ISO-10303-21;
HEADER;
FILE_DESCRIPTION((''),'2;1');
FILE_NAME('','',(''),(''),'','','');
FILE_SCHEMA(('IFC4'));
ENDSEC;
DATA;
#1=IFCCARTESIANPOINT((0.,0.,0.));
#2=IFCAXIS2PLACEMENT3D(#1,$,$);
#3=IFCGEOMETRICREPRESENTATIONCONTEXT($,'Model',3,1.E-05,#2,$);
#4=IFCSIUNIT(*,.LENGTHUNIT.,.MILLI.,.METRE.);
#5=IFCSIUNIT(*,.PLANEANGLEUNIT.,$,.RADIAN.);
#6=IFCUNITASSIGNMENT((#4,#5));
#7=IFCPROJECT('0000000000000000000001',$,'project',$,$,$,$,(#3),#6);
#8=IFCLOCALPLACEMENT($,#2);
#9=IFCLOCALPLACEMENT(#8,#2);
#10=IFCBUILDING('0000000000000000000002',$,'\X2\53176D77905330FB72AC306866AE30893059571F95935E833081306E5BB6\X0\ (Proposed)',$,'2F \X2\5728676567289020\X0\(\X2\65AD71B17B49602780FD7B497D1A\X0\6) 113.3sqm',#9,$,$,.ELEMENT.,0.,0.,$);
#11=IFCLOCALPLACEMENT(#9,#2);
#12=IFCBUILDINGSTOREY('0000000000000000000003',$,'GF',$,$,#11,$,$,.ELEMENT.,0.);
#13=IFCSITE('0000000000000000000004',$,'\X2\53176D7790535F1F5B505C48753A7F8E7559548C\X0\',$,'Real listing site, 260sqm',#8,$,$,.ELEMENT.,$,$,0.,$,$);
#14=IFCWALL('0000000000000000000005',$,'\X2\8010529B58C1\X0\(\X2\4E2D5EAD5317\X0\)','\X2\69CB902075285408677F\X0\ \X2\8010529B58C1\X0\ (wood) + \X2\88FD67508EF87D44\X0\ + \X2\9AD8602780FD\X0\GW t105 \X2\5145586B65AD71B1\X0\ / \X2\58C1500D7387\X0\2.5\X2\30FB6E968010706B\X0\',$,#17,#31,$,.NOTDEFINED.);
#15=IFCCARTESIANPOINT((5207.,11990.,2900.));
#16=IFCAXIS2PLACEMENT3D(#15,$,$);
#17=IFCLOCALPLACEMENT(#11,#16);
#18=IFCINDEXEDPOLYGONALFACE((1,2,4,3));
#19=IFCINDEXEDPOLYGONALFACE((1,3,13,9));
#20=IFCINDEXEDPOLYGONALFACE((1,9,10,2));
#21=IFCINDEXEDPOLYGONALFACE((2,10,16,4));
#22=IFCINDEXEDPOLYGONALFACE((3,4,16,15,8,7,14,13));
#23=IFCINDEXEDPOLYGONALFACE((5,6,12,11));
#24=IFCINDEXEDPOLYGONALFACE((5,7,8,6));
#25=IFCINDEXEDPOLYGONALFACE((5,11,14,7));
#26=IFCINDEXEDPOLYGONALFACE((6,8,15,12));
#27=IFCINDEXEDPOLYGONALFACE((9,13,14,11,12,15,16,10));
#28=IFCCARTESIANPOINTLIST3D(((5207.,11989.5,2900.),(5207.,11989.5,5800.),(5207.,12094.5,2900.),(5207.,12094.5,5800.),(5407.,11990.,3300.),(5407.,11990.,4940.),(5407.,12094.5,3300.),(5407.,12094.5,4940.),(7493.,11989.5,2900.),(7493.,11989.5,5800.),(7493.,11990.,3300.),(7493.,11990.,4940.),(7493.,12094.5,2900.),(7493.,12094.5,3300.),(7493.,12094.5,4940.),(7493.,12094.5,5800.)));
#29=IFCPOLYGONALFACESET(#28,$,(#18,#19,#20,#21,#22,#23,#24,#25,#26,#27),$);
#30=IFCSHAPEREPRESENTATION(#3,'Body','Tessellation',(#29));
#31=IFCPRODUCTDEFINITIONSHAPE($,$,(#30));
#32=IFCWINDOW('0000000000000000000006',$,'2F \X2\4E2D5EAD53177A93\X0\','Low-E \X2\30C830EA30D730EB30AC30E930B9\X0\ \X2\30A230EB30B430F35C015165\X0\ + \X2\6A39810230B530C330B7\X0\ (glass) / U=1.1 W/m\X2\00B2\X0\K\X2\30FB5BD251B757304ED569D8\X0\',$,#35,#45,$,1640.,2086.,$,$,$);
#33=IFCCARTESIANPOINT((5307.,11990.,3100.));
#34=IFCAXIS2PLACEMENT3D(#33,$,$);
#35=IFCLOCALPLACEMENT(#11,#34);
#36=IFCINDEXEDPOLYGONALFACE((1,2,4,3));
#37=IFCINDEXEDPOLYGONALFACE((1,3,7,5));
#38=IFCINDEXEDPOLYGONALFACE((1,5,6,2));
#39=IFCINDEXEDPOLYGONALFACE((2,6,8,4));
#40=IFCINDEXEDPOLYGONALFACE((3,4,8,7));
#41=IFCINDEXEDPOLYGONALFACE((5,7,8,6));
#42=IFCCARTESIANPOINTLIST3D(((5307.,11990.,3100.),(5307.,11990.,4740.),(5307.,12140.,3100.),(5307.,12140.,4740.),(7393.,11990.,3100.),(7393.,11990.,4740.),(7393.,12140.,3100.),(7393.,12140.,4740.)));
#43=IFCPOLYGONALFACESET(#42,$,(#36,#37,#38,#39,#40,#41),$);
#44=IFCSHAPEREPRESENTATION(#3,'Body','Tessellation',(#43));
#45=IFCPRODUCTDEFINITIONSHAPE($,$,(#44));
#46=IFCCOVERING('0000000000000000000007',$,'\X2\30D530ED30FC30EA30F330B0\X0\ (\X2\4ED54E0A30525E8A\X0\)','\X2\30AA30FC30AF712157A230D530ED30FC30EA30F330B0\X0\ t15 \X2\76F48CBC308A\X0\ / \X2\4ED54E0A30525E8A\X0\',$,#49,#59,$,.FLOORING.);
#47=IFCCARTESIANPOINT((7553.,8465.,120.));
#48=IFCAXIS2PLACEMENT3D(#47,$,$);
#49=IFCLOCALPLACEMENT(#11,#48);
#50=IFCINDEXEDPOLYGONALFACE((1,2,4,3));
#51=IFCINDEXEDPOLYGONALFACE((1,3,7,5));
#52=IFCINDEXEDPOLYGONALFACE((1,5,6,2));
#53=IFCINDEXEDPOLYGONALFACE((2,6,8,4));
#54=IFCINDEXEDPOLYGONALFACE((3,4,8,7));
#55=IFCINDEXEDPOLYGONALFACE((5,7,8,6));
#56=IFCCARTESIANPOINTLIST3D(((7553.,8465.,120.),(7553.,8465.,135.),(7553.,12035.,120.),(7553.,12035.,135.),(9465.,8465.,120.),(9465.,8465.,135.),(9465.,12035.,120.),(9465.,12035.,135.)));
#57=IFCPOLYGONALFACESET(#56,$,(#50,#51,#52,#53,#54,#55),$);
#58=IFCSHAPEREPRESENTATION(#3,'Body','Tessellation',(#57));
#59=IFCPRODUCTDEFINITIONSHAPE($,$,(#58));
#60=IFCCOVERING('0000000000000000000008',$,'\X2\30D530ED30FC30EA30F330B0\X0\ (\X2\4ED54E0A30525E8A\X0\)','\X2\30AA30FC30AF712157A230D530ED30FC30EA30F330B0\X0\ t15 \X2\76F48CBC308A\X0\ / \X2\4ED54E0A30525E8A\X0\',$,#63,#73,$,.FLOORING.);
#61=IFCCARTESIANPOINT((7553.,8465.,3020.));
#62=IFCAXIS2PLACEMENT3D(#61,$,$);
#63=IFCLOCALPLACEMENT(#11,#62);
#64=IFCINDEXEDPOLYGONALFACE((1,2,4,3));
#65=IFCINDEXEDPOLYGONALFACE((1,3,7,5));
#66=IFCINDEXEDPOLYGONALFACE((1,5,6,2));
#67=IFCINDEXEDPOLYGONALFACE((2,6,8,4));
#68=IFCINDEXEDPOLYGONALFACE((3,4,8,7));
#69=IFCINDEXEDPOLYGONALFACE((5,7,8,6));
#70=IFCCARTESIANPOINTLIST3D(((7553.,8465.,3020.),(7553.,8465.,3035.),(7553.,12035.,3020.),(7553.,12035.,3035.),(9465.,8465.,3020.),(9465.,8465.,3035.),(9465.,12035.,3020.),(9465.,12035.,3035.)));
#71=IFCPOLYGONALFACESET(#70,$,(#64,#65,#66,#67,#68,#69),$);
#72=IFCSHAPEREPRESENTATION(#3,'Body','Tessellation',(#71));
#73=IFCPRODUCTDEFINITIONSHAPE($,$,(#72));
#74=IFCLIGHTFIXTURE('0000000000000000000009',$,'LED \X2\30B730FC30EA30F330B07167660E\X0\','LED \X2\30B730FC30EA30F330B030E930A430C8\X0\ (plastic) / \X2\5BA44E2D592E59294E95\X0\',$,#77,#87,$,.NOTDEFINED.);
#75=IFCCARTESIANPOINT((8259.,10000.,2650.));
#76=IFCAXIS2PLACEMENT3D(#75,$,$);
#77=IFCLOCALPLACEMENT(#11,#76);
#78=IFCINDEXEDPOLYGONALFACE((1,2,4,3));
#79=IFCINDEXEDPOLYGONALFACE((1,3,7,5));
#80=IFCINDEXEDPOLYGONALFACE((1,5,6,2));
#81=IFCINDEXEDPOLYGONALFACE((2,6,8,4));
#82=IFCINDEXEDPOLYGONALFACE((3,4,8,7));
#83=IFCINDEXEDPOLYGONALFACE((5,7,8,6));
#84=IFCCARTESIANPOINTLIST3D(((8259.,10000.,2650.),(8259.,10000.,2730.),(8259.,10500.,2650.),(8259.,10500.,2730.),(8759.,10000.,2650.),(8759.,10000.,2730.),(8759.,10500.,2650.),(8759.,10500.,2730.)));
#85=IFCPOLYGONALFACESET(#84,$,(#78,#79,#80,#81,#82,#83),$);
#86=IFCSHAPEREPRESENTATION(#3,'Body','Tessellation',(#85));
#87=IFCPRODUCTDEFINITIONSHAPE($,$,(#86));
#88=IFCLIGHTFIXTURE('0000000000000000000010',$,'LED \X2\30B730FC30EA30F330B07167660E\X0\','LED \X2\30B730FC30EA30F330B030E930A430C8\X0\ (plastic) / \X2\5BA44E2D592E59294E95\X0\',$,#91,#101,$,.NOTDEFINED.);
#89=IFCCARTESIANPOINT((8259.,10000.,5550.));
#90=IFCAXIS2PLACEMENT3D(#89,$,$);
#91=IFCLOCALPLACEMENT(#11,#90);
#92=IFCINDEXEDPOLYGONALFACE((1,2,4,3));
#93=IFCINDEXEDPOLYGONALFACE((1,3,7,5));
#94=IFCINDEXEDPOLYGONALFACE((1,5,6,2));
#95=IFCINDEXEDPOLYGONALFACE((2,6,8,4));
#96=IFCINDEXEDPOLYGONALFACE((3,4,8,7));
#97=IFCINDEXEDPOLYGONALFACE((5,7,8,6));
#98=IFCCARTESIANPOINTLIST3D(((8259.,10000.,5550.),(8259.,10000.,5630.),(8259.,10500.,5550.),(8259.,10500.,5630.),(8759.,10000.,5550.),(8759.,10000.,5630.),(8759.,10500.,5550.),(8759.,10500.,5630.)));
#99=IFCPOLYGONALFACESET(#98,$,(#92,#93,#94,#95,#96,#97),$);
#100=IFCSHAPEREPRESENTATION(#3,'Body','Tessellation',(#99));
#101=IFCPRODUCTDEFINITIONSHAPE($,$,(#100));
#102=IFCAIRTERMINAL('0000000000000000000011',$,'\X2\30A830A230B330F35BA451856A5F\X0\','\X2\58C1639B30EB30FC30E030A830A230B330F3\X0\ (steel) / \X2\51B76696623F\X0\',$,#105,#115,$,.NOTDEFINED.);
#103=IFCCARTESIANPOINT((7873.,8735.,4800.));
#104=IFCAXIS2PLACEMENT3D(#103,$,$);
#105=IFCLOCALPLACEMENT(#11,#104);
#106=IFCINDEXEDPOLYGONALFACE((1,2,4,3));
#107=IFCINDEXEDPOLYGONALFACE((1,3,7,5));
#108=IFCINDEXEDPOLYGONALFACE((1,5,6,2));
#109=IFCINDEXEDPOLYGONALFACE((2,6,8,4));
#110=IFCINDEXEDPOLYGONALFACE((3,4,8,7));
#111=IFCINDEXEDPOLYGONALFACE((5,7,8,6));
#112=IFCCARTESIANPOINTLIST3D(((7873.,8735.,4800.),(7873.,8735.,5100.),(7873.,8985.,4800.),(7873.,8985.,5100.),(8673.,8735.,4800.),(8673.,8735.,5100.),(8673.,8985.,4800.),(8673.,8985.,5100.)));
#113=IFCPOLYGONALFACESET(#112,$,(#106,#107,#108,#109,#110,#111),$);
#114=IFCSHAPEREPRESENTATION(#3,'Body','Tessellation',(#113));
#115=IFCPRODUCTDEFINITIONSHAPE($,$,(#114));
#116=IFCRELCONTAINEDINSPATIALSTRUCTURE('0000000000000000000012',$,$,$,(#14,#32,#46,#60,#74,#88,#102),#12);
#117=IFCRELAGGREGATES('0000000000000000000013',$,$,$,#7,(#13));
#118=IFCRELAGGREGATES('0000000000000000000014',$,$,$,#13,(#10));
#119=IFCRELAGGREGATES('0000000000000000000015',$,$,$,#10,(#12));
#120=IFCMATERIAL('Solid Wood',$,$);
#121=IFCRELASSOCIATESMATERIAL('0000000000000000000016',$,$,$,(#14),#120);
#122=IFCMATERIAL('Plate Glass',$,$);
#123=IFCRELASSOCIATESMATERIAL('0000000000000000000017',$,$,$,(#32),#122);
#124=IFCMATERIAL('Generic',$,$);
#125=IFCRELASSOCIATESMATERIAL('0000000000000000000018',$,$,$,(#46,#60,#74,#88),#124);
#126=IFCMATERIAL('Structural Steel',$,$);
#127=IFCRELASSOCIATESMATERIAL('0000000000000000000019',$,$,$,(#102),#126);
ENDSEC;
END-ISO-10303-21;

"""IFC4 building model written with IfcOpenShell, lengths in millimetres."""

from ifc_helpers import new_model, si_unit, frame, frame_2d, origin, place, context, project, spatial, rectangle, extrude, material, element, fill, save


model = new_model("IFC4")

# Units and contexts
model_context = context("Model", 3, precision=1e-05, world=origin())
ifc_project = project(units=[si_unit("LENGTHUNIT", "METRE", prefix="MILLI"), si_unit("PLANEANGLEUNIT", "RADIAN")], contexts=[model_context])

# Site, building, storey
site_placement = place(None, origin())
site = spatial("IfcSite", under=ifc_project, at=site_placement, Name="北海道弟子屈町美留和", ObjectType="Real listing site, 260sqm", CompositionType="ELEMENT", RefElevation=0.0)
building_placement = place(site_placement, origin())
building = spatial("IfcBuilding", under=site, at=building_placement, Name="北海道・犬と暮らす土間広めの家 (Proposed)", ObjectType="2F 在来木造(断熱等性能等級6) 113.3sqm", CompositionType="ELEMENT", ElevationOfRefHeight=0.0, ElevationOfTerrain=0.0)
storey_placement = place(building_placement, origin())
storey = spatial("IfcBuildingStorey", under=building, at=storey_placement, Name="GF", CompositionType="ELEMENT", Elevation=0.0)

# Shared definitions
ifc_material_1 = material(Name="Solid Wood")

# Wall, opening, window
ifc_material_2 = material(Name="Plate Glass")
wall_1_placement = place(storey_placement, frame((5207.0, 11990.0, 2900.0)))
wall_1 = element("IfcWall", 1, at=wall_1_placement, inside=storey, material=ifc_material_1, Name="耐力壁(中庭北)", Description="構造用合板 耐力壁 (wood) + 製材軸組 + 高性能GW t105 充填断熱 / 壁倍率2.5・準耐火", PredefinedType="NOTDEFINED", context=model_context, shape_type="SweptSolid", body=[
    extrude(rectangle(XDim=2286.0, YDim=105.0, at=frame_2d((1143.0, 52.0))), frame((5207.0, 11990.0, 2900.0)), (0.0, 0.0, 1.0), 2900.0),
])
opening_1_placement = place(storey_placement, frame((5307.0, 11990.0, 3100.0)))
opening_1 = element("IfcOpeningElement", 2, at=opening_1_placement, cuts=wall_1, PredefinedType="NOTDEFINED", context=model_context, shape_type="SweptSolid", body=[
    extrude(rectangle(XDim=2086.0, YDim=150.0, at=frame_2d((1043.0, 75.0))), frame((5307.0, 11990.0, 3100.0)), (0.0, 0.0, 1.0), 1640.0),
])
window_1_placement = place(storey_placement, frame((5307.0, 11990.0, 3100.0)))
window_1 = element("IfcWindow", 3, at=window_1_placement, inside=storey, material=ifc_material_2, Name="2F 中庭北窓", Description="Low-E トリプルガラス アルゴン封入 + 樹脂サッシ (glass) / U=1.1 W/m²K・寒冷地仕様", OverallHeight=1640.0, OverallWidth=2086.0, context=model_context, shape_type="SweptSolid", body=[
    extrude(rectangle(XDim=2086.0, YDim=150.0, at=frame_2d((1043.0, 75.0))), frame((5307.0, 11990.0, 3100.0)), (0.0, 0.0, 1.0), 1640.0),
])
fill(opening_1, window_1)

# Coverings
ifc_material_3 = material(Name="Generic")
covering_1_placement = place(storey_placement, frame((7553.0, 8465.0, 120.0)))
element("IfcCovering", 4, at=covering_1_placement, inside=storey, material=ifc_material_3, Name="フローリング (仕上げ床)", Description="オーク無垢フローリング t15 直貼り / 仕上げ床", PredefinedType="FLOORING", context=model_context, shape_type="SweptSolid", body=[
    extrude(rectangle(XDim=1912.0, YDim=3570.0, at=frame_2d((956.0, 1785.0))), frame((7553.0, 8465.0, 120.0)), (0.0, 0.0, 1.0), 15.0),
])
covering_2_placement = place(storey_placement, frame((7553.0, 8465.0, 3020.0)))
element("IfcCovering", 5, at=covering_2_placement, inside=storey, material=ifc_material_3, Name="フローリング (仕上げ床)", Description="オーク無垢フローリング t15 直貼り / 仕上げ床", PredefinedType="FLOORING", context=model_context, shape_type="SweptSolid", body=[
    extrude(rectangle(XDim=1912.0, YDim=3570.0, at=frame_2d((956.0, 1785.0))), frame((7553.0, 8465.0, 3020.0)), (0.0, 0.0, 1.0), 15.0),
])

# Light fixtures
light_fixture_1_placement = place(storey_placement, frame((8259.0, 10000.0, 2650.0)))
element("IfcLightFixture", 6, at=light_fixture_1_placement, inside=storey, material=ifc_material_3, Name="LED シーリング照明", Description="LED シーリングライト (plastic) / 室中央天井", PredefinedType="NOTDEFINED", context=model_context, shape_type="SweptSolid", body=[
    extrude(rectangle(XDim=500.0, YDim=500.0, at=frame_2d((250.0, 250.0))), frame((8259.0, 10000.0, 2650.0)), (0.0, 0.0, 1.0), 80.0),
])
light_fixture_2_placement = place(storey_placement, frame((8259.0, 10000.0, 5550.0)))
element("IfcLightFixture", 7, at=light_fixture_2_placement, inside=storey, material=ifc_material_3, Name="LED シーリング照明", Description="LED シーリングライト (plastic) / 室中央天井", PredefinedType="NOTDEFINED", context=model_context, shape_type="SweptSolid", body=[
    extrude(rectangle(XDim=500.0, YDim=500.0, at=frame_2d((250.0, 250.0))), frame((8259.0, 10000.0, 5550.0)), (0.0, 0.0, 1.0), 80.0),
])

# Air terminal
ifc_material_4 = material(Name="Structural Steel")
air_terminal_placement = place(storey_placement, frame((7873.0, 8735.0, 4800.0)))
element("IfcAirTerminal", 8, at=air_terminal_placement, inside=storey, material=ifc_material_4, Name="エアコン室内機", Description="壁掛ルームエアコン (steel) / 冷暖房", PredefinedType="NOTDEFINED", context=model_context, shape_type="SweptSolid", body=[
    extrude(rectangle(XDim=800.0, YDim=250.0, at=frame_2d((400.0, 125.0))), frame((7873.0, 8735.0, 4800.0)), (0.0, 0.0, 1.0), 300.0),
])

save(model, "model.ifc")
